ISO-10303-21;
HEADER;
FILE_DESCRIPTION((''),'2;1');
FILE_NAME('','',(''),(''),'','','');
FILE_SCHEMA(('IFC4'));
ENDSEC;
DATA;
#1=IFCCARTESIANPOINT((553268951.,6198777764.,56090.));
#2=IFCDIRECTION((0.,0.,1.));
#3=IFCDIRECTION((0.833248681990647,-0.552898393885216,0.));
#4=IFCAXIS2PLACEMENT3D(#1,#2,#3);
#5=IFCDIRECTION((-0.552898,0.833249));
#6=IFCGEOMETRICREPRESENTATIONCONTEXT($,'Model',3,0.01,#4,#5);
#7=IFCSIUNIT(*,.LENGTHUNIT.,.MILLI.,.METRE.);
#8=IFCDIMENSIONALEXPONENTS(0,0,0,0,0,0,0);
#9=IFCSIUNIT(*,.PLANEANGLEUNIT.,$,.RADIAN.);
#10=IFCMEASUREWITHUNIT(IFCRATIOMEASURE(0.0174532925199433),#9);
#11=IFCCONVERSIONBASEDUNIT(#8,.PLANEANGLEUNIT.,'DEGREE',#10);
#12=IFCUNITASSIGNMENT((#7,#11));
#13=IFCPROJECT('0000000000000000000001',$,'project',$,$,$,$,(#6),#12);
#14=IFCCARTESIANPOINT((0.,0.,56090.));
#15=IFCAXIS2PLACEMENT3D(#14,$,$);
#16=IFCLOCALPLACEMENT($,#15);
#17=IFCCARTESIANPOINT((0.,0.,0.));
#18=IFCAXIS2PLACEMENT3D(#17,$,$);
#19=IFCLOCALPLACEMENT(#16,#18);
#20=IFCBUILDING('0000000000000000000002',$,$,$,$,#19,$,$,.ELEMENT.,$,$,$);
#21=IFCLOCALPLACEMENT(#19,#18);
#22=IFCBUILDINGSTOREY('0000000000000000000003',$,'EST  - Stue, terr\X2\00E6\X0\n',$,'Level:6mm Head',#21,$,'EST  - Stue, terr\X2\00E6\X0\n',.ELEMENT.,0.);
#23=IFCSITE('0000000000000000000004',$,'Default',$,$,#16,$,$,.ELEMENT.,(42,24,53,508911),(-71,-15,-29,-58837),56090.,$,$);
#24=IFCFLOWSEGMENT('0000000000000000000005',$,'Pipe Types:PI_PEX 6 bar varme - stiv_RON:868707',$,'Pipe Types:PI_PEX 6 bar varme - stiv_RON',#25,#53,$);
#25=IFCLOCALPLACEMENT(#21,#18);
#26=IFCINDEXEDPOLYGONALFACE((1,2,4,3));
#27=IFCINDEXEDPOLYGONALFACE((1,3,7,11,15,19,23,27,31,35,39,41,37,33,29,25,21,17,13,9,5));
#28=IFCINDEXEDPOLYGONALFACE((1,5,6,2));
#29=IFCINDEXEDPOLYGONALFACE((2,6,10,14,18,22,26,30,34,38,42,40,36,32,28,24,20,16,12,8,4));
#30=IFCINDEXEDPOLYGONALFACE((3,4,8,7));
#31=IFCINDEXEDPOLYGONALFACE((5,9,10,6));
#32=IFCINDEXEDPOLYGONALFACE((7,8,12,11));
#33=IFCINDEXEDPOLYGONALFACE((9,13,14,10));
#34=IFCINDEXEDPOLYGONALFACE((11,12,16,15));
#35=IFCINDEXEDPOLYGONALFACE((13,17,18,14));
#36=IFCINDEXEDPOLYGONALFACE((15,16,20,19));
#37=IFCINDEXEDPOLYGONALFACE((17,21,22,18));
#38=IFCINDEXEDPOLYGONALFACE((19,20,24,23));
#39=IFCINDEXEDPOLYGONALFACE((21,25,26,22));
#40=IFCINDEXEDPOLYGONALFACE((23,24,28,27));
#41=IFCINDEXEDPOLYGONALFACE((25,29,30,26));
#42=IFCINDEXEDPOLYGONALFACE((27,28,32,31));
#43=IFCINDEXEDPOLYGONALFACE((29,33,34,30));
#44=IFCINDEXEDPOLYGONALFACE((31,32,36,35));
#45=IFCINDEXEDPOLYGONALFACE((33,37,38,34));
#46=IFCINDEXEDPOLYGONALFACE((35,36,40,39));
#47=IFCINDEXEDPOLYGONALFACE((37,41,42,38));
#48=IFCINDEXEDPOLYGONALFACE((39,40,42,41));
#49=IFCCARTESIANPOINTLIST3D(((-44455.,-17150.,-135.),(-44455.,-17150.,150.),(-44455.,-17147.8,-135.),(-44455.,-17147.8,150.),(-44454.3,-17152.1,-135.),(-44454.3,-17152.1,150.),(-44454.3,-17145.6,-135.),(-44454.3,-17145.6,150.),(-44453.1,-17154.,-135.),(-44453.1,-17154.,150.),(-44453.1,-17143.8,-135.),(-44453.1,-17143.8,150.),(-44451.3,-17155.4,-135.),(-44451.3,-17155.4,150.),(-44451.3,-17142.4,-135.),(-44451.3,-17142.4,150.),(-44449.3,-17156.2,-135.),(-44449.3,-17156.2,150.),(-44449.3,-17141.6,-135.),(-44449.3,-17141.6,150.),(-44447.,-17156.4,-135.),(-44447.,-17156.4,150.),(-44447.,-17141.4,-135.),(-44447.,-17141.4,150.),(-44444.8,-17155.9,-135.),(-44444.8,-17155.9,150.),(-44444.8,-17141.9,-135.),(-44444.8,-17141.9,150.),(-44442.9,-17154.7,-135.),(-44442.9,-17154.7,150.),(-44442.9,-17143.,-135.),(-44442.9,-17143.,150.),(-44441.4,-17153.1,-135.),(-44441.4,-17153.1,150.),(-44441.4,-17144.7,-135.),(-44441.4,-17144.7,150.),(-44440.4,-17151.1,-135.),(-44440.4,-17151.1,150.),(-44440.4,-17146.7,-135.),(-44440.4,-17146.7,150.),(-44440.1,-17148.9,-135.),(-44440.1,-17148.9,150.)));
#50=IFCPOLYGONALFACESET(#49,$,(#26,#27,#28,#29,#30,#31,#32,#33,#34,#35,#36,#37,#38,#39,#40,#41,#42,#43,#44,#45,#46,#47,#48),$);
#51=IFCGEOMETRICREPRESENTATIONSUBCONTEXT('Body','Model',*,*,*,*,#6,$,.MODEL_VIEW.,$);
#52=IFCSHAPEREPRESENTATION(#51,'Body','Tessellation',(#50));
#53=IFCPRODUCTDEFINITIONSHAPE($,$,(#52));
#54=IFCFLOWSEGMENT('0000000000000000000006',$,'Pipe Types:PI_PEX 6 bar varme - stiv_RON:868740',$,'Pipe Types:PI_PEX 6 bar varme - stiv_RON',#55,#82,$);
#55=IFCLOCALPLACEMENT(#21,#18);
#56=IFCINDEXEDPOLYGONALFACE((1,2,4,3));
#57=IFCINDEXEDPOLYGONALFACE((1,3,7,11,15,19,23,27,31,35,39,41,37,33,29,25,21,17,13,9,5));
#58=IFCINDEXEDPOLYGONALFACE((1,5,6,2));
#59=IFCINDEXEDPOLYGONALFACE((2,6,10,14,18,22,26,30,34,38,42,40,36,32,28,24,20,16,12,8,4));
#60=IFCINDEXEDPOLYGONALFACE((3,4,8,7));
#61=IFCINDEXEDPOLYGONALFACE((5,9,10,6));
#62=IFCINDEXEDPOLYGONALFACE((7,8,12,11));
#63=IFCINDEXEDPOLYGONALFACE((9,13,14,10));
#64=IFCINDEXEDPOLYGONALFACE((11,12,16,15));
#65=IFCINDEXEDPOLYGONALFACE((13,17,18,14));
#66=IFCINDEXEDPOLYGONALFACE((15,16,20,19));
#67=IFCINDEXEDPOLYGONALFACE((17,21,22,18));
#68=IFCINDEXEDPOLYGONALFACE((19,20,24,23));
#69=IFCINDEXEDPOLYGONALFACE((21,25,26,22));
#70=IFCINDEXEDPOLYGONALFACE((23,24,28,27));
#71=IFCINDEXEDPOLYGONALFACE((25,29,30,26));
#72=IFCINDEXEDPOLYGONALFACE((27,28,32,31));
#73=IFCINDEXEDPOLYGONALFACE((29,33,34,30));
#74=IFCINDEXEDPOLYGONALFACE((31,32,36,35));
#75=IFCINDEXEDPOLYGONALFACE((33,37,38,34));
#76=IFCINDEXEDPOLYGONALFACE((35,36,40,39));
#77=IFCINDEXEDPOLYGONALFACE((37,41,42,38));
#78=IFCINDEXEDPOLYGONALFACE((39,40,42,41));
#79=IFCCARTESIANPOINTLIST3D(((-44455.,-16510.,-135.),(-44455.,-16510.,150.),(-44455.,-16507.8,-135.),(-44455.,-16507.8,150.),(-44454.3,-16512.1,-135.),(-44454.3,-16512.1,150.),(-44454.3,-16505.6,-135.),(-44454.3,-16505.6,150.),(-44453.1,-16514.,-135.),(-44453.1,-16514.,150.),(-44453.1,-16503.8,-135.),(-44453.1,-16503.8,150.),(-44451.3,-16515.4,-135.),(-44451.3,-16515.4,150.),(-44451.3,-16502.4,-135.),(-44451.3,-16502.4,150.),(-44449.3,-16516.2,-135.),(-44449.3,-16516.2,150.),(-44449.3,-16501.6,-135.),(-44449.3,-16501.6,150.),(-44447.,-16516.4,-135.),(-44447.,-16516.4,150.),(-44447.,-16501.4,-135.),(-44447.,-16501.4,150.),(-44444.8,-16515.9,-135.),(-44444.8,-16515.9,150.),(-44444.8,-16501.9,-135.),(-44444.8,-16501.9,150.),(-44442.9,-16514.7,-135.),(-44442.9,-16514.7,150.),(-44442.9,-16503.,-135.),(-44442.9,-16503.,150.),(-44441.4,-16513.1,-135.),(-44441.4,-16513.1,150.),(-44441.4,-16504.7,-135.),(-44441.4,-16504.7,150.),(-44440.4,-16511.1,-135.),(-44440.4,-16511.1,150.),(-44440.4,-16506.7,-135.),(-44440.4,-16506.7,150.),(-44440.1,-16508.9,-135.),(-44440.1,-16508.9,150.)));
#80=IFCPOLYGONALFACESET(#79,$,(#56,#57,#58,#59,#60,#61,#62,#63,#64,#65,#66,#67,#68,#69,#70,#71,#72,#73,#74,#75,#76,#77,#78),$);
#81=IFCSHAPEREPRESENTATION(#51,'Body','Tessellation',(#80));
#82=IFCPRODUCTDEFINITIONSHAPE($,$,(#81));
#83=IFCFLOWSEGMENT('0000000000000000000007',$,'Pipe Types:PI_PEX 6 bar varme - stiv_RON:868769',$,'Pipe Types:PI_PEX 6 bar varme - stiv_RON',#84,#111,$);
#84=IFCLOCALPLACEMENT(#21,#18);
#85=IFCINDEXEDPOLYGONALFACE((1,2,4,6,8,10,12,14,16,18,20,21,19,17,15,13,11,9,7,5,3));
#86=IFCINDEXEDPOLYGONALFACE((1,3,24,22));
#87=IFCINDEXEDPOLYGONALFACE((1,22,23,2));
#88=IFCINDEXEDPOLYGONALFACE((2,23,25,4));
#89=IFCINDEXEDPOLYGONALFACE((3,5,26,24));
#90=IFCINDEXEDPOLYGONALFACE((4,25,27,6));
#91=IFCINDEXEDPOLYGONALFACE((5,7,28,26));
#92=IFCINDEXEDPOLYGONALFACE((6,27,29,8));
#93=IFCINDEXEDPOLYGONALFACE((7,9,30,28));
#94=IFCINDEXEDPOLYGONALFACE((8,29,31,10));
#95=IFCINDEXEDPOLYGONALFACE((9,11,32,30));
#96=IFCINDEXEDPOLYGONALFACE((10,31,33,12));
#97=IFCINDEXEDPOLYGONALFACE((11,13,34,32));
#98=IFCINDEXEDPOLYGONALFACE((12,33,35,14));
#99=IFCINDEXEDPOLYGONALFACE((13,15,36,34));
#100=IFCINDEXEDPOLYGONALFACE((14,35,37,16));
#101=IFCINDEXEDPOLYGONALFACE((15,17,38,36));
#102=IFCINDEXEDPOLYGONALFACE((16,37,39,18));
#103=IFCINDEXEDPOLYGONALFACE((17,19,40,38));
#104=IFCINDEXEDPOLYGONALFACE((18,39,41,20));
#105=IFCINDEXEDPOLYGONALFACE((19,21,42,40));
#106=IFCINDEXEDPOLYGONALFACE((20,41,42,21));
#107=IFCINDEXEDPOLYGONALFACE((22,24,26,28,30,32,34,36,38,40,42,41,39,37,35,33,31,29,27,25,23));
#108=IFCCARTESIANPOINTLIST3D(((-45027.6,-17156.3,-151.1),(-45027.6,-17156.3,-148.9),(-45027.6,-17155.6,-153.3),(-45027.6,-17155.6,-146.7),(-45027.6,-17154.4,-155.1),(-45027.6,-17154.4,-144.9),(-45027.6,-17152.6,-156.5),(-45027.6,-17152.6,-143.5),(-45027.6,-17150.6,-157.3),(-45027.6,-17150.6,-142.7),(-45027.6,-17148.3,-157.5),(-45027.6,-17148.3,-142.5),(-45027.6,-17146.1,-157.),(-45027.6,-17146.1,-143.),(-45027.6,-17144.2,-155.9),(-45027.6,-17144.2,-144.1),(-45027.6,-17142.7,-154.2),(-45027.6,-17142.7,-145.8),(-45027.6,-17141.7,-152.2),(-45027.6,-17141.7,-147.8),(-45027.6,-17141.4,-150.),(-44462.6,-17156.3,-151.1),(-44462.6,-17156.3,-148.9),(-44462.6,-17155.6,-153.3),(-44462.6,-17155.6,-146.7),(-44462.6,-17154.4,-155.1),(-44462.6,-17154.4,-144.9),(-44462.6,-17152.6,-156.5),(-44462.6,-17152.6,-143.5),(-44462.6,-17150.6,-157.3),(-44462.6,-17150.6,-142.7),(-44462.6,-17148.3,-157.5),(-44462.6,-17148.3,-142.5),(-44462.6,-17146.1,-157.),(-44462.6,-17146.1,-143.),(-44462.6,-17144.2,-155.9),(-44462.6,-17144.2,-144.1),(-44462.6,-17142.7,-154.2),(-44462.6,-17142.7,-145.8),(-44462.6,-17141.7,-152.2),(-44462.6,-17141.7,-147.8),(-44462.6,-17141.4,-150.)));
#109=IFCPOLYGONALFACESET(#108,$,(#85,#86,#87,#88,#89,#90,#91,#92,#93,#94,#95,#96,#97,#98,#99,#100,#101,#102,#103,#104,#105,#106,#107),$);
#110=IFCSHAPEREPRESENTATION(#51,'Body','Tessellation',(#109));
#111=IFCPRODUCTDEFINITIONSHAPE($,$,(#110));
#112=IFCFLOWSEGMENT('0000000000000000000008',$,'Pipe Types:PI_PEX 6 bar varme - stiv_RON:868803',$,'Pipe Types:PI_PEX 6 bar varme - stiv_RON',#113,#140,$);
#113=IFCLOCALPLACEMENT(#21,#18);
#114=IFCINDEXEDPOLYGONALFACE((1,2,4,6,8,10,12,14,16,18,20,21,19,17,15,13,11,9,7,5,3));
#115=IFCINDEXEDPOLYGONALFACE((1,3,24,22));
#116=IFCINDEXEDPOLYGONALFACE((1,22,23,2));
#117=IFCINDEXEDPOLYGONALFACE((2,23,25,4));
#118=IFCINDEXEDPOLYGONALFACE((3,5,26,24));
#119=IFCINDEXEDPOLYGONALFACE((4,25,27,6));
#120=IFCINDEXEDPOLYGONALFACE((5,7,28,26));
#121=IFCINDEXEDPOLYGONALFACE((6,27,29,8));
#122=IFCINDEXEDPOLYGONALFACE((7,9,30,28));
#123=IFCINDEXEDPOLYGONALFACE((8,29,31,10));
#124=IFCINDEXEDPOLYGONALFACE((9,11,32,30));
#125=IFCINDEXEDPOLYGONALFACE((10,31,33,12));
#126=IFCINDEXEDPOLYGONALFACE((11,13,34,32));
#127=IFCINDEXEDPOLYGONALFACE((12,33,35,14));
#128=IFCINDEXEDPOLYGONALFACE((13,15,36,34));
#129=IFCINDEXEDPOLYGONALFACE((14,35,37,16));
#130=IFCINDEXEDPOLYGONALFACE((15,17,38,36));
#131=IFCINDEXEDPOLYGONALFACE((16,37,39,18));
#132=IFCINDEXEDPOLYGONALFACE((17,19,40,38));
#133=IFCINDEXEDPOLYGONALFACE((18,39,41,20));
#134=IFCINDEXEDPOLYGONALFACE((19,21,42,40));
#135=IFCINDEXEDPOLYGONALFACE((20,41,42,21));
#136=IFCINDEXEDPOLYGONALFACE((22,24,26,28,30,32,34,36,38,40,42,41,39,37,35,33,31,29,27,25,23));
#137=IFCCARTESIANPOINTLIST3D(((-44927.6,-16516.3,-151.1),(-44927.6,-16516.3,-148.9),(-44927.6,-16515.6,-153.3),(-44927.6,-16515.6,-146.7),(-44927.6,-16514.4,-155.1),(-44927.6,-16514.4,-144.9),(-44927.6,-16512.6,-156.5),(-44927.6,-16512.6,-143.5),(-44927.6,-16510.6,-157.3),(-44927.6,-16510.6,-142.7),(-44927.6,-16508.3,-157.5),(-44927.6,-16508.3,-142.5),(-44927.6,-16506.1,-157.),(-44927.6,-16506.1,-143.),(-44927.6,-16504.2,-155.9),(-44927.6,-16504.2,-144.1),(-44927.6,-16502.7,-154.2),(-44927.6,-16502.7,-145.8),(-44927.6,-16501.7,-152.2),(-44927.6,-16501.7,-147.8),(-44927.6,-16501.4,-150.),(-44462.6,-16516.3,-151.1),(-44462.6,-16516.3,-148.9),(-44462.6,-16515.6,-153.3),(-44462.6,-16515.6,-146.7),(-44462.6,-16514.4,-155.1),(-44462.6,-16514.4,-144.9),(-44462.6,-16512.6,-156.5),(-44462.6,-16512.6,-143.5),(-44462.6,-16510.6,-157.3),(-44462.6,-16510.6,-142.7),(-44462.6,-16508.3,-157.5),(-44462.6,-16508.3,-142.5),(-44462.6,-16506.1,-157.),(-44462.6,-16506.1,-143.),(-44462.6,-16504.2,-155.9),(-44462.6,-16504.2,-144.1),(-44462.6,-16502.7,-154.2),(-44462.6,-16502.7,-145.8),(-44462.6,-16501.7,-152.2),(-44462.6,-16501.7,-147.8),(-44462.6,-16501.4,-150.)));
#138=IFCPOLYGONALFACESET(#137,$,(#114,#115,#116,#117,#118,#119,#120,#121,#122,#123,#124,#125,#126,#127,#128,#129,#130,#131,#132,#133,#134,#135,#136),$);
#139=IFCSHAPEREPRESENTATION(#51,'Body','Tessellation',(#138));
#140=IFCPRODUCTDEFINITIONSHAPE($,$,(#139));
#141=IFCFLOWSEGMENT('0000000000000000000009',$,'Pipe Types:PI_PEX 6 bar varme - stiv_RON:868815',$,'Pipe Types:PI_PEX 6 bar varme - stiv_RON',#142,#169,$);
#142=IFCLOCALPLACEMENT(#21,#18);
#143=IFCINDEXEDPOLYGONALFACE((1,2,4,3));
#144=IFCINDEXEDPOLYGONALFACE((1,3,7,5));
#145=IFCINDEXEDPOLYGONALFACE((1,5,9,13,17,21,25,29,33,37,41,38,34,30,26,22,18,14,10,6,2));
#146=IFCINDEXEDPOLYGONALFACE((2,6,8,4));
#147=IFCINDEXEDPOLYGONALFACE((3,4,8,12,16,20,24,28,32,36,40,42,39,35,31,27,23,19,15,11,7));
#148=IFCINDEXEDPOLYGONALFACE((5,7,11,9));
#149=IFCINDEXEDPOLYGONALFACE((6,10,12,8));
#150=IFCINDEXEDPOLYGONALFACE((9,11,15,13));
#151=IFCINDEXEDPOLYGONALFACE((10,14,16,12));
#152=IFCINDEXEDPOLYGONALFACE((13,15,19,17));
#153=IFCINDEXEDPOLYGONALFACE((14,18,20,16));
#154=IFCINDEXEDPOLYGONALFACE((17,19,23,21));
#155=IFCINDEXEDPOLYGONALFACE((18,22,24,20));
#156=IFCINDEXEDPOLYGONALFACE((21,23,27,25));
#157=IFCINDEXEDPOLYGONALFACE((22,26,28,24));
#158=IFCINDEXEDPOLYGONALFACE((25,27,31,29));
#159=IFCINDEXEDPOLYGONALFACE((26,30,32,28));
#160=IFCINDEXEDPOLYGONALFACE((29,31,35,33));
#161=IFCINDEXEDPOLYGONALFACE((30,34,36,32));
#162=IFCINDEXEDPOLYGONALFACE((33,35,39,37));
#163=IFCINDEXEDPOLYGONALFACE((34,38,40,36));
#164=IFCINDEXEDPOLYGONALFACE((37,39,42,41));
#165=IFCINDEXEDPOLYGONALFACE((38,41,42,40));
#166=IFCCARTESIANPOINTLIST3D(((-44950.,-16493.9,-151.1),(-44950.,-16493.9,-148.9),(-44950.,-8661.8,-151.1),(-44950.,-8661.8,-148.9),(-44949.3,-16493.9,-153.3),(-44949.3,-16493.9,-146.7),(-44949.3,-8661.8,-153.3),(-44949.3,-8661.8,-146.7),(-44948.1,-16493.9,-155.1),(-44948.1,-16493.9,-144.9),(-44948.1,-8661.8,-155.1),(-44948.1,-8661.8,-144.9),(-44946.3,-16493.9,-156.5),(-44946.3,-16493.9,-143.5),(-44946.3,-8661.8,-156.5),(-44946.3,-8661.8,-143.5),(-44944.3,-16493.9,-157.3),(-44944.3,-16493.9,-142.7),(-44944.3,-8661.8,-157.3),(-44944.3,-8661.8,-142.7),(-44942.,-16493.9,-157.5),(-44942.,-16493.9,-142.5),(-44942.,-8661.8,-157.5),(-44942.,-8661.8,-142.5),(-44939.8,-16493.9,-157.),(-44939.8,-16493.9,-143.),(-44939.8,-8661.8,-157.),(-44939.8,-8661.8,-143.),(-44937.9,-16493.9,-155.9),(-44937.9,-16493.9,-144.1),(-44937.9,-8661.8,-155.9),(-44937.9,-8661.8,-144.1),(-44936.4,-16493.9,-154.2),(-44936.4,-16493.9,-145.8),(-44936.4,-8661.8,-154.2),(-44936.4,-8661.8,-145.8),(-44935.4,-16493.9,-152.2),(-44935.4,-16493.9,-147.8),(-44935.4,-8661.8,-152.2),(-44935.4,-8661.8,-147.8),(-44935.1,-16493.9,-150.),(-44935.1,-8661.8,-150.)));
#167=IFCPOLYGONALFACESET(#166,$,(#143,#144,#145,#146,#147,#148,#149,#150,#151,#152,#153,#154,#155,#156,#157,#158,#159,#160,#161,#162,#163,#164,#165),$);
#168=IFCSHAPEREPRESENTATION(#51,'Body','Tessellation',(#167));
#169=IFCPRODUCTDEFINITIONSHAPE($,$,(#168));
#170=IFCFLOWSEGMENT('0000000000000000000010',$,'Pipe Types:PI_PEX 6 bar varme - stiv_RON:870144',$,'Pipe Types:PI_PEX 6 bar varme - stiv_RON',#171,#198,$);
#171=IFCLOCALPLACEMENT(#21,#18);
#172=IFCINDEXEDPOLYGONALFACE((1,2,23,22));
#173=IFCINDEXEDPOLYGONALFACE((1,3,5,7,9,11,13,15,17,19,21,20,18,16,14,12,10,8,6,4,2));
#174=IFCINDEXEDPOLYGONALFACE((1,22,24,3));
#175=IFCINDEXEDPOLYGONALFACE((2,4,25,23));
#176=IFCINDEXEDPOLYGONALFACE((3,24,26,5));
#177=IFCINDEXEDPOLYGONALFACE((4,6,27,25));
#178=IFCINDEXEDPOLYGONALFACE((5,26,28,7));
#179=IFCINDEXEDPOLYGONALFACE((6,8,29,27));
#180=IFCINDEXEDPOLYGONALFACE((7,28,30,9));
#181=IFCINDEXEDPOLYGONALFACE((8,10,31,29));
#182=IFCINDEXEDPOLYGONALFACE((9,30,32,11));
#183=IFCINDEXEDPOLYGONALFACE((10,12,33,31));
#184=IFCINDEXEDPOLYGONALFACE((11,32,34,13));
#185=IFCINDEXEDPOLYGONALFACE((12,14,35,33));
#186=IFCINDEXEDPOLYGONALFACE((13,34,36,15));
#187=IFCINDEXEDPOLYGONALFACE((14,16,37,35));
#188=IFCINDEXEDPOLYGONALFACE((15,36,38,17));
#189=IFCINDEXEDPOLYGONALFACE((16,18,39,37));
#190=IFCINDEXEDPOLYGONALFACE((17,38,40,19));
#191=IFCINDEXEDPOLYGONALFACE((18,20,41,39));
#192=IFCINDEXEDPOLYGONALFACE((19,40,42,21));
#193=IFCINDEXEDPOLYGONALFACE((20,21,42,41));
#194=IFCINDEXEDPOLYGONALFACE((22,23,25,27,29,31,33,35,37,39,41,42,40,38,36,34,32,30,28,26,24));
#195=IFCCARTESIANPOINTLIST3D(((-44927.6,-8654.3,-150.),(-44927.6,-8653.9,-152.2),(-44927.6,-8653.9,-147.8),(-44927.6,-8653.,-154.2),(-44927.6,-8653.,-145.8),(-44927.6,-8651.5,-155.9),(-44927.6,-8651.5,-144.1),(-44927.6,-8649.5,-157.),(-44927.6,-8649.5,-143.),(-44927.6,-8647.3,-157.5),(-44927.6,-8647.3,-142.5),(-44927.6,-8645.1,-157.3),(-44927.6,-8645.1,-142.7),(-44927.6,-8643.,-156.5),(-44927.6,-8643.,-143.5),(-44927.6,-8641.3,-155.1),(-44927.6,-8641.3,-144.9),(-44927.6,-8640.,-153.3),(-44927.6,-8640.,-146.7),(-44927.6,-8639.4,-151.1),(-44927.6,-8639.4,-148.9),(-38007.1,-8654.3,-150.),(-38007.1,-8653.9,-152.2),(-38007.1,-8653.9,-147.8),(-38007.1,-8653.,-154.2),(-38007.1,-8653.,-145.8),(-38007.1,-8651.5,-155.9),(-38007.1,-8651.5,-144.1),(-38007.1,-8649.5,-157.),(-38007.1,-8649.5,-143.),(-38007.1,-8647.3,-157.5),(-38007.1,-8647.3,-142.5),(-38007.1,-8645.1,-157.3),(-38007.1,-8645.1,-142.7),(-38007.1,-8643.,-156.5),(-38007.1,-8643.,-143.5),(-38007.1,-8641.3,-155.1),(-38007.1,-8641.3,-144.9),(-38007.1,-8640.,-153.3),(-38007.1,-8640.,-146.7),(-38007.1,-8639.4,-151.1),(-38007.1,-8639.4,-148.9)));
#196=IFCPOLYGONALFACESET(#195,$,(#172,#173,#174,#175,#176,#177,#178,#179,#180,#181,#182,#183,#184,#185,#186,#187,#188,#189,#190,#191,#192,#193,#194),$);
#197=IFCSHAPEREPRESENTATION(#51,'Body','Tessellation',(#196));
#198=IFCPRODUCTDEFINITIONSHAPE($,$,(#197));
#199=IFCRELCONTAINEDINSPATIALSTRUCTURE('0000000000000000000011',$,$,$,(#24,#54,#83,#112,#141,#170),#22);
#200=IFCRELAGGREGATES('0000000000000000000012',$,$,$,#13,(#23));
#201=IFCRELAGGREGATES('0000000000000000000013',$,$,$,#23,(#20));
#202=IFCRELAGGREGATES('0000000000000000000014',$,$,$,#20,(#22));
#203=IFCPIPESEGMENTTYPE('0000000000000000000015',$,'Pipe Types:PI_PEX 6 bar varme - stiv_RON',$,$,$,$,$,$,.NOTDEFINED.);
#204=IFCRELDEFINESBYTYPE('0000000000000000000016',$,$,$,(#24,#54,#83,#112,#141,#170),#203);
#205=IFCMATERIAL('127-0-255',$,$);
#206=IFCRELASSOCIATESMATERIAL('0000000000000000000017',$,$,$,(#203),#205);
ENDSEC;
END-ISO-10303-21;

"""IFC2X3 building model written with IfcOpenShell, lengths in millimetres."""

from ifc_helpers import new_model, entity, si_unit, converted_unit, direction, frame, frame_2d, origin, origin_2d_with_axis, place, context, subcontext, project, spatial, circle, extrude, material, type_object, element, save


model = new_model("IFC2X3")

# Units and contexts
model_context = context("Model", 3, precision=0.01, world=frame((553268951.0, 6198777764.0, 56090.0), z_axis=(0.0, 0.0, 1.0), x_axis=(0.833248681990647, -0.552898393885216, 0.0)), true_north=direction((-0.552898, 0.833249)))
body_context = subcontext(model_context, "Body", "Model", "MODEL_VIEW")
ifc_project = project(units=[si_unit("LENGTHUNIT", "METRE", prefix="MILLI"), converted_unit("PLANEANGLEUNIT", "DEGREE", entity("IfcRatioMeasure", 0.0174532925199433), si_unit("PLANEANGLEUNIT", "RADIAN"), dimensions=[0, 0, 0, 0, 0, 0, 0])], contexts=[model_context])

# Site, building, storey
site_placement = place(None, frame((0.0, 0.0, 56090.0)))
site = spatial("IfcSite", under=ifc_project, at=site_placement, Name="Default", CompositionType="ELEMENT", RefLatitude=(42, 24, 53, 508911), RefLongitude=(-71, -15, -29, -58837), RefElevation=56090.0)
building_placement = place(site_placement, origin())
building = spatial("IfcBuilding", under=site, at=building_placement, CompositionType="ELEMENT")
storey_placement = place(building_placement, frame((0.0, 0.0, 0.0)))
storey = spatial("IfcBuildingStorey", under=building, at=storey_placement, Name="EST  - Stue, terræn", ObjectType="Level:6mm Head", LongName="EST  - Stue, terræn", CompositionType="ELEMENT", Elevation=0.0)

# Flow segments
ifc_material = material(Name="127-0-255")
pipe_segment_type = type_object("IfcPipeSegmentType", Name="Pipe Types:PI_PEX 6 bar varme - stiv_RON", PredefinedType="NOTDEFINED", material=ifc_material)
flow_segment_1_placement = place(storey_placement, origin())
element("IfcFlowSegment", 1, at=flow_segment_1_placement, inside=storey, type_object=pipe_segment_type, Name="Pipe Types:PI_PEX 6 bar varme - stiv_RON:868707", ObjectType="Pipe Types:PI_PEX 6 bar varme - stiv_RON", context=body_context, shape_type="SweptSolid", body=[
    extrude(circle(Radius=7.5, at=frame_2d((0.0, 0.0), x_axis=(1.0, 0.0))), frame((-44447.6, -17148.9, -135.0)), (0.0, 0.0, 1.0), 285.0),
])
flow_segment_2_placement = place(storey_placement, origin())
element("IfcFlowSegment", 2, at=flow_segment_2_placement, inside=storey, type_object=pipe_segment_type, Name="Pipe Types:PI_PEX 6 bar varme - stiv_RON:868740", ObjectType="Pipe Types:PI_PEX 6 bar varme - stiv_RON", context=body_context, shape_type="SweptSolid", body=[
    extrude(circle(Radius=7.5, at=frame_2d((0.0, 0.0), x_axis=(1.0, 0.0))), frame((-44447.6, -16508.9, -135.0)), (0.0, 0.0, 1.0), 285.0),
])
flow_segment_3_placement = place(storey_placement, origin())
element("IfcFlowSegment", 3, at=flow_segment_3_placement, inside=storey, type_object=pipe_segment_type, Name="Pipe Types:PI_PEX 6 bar varme - stiv_RON:868769", ObjectType="Pipe Types:PI_PEX 6 bar varme - stiv_RON", context=body_context, shape_type="SweptSolid", body=[
    extrude(circle(Radius=7.5, at=frame_2d((0.0, 0.0), x_axis=(1.0, 0.0))), frame((-45027.6, -17148.9, -150.0), z_axis=(1.0, 0.0, 0.0), x_axis=(0.0, 1.0, 0.0)), (0.0, 0.0, 1.0), 565.0),
])
flow_segment_4_placement = place(storey_placement, origin())
element("IfcFlowSegment", 4, at=flow_segment_4_placement, inside=storey, type_object=pipe_segment_type, Name="Pipe Types:PI_PEX 6 bar varme - stiv_RON:868803", ObjectType="Pipe Types:PI_PEX 6 bar varme - stiv_RON", context=body_context, shape_type="SweptSolid", body=[
    extrude(circle(Radius=7.5, at=frame_2d((0.0, 0.0), x_axis=(1.0, 0.0))), frame((-44927.6, -16508.9, -150.0), z_axis=(1.0, 0.0, 0.0), x_axis=(0.0, 1.0, 0.0)), (0.0, 0.0, 1.0), 465.0),
])
flow_segment_5_placement = place(storey_placement, origin())
element("IfcFlowSegment", 5, at=flow_segment_5_placement, inside=storey, type_object=pipe_segment_type, Name="Pipe Types:PI_PEX 6 bar varme - stiv_RON:868815", ObjectType="Pipe Types:PI_PEX 6 bar varme - stiv_RON", context=body_context, shape_type="SweptSolid", body=[
    extrude(circle(Radius=7.5, at=origin_2d_with_axis()), frame((-44942.6, -16493.9, -150.0), z_axis=(0.0, 1.0, 0.0), x_axis=(1.0, 0.0, 0.0)), (0.0, 0.0, 1.0), 7832.1),
])
flow_segment_6_placement = place(storey_placement, origin())
element("IfcFlowSegment", 6, at=flow_segment_6_placement, inside=storey, type_object=pipe_segment_type, Name="Pipe Types:PI_PEX 6 bar varme - stiv_RON:870144", ObjectType="Pipe Types:PI_PEX 6 bar varme - stiv_RON", context=body_context, shape_type="SweptSolid", body=[
    extrude(circle(Radius=7.5, at=origin_2d_with_axis()), frame((-44927.6, -8646.8, -150.0), z_axis=(1.0, 0.0, 0.0), x_axis=(0.0, -1.0, 0.0)), (0.0, 0.0, 1.0), 6920.5),
])

save(model, "model.ifc")
